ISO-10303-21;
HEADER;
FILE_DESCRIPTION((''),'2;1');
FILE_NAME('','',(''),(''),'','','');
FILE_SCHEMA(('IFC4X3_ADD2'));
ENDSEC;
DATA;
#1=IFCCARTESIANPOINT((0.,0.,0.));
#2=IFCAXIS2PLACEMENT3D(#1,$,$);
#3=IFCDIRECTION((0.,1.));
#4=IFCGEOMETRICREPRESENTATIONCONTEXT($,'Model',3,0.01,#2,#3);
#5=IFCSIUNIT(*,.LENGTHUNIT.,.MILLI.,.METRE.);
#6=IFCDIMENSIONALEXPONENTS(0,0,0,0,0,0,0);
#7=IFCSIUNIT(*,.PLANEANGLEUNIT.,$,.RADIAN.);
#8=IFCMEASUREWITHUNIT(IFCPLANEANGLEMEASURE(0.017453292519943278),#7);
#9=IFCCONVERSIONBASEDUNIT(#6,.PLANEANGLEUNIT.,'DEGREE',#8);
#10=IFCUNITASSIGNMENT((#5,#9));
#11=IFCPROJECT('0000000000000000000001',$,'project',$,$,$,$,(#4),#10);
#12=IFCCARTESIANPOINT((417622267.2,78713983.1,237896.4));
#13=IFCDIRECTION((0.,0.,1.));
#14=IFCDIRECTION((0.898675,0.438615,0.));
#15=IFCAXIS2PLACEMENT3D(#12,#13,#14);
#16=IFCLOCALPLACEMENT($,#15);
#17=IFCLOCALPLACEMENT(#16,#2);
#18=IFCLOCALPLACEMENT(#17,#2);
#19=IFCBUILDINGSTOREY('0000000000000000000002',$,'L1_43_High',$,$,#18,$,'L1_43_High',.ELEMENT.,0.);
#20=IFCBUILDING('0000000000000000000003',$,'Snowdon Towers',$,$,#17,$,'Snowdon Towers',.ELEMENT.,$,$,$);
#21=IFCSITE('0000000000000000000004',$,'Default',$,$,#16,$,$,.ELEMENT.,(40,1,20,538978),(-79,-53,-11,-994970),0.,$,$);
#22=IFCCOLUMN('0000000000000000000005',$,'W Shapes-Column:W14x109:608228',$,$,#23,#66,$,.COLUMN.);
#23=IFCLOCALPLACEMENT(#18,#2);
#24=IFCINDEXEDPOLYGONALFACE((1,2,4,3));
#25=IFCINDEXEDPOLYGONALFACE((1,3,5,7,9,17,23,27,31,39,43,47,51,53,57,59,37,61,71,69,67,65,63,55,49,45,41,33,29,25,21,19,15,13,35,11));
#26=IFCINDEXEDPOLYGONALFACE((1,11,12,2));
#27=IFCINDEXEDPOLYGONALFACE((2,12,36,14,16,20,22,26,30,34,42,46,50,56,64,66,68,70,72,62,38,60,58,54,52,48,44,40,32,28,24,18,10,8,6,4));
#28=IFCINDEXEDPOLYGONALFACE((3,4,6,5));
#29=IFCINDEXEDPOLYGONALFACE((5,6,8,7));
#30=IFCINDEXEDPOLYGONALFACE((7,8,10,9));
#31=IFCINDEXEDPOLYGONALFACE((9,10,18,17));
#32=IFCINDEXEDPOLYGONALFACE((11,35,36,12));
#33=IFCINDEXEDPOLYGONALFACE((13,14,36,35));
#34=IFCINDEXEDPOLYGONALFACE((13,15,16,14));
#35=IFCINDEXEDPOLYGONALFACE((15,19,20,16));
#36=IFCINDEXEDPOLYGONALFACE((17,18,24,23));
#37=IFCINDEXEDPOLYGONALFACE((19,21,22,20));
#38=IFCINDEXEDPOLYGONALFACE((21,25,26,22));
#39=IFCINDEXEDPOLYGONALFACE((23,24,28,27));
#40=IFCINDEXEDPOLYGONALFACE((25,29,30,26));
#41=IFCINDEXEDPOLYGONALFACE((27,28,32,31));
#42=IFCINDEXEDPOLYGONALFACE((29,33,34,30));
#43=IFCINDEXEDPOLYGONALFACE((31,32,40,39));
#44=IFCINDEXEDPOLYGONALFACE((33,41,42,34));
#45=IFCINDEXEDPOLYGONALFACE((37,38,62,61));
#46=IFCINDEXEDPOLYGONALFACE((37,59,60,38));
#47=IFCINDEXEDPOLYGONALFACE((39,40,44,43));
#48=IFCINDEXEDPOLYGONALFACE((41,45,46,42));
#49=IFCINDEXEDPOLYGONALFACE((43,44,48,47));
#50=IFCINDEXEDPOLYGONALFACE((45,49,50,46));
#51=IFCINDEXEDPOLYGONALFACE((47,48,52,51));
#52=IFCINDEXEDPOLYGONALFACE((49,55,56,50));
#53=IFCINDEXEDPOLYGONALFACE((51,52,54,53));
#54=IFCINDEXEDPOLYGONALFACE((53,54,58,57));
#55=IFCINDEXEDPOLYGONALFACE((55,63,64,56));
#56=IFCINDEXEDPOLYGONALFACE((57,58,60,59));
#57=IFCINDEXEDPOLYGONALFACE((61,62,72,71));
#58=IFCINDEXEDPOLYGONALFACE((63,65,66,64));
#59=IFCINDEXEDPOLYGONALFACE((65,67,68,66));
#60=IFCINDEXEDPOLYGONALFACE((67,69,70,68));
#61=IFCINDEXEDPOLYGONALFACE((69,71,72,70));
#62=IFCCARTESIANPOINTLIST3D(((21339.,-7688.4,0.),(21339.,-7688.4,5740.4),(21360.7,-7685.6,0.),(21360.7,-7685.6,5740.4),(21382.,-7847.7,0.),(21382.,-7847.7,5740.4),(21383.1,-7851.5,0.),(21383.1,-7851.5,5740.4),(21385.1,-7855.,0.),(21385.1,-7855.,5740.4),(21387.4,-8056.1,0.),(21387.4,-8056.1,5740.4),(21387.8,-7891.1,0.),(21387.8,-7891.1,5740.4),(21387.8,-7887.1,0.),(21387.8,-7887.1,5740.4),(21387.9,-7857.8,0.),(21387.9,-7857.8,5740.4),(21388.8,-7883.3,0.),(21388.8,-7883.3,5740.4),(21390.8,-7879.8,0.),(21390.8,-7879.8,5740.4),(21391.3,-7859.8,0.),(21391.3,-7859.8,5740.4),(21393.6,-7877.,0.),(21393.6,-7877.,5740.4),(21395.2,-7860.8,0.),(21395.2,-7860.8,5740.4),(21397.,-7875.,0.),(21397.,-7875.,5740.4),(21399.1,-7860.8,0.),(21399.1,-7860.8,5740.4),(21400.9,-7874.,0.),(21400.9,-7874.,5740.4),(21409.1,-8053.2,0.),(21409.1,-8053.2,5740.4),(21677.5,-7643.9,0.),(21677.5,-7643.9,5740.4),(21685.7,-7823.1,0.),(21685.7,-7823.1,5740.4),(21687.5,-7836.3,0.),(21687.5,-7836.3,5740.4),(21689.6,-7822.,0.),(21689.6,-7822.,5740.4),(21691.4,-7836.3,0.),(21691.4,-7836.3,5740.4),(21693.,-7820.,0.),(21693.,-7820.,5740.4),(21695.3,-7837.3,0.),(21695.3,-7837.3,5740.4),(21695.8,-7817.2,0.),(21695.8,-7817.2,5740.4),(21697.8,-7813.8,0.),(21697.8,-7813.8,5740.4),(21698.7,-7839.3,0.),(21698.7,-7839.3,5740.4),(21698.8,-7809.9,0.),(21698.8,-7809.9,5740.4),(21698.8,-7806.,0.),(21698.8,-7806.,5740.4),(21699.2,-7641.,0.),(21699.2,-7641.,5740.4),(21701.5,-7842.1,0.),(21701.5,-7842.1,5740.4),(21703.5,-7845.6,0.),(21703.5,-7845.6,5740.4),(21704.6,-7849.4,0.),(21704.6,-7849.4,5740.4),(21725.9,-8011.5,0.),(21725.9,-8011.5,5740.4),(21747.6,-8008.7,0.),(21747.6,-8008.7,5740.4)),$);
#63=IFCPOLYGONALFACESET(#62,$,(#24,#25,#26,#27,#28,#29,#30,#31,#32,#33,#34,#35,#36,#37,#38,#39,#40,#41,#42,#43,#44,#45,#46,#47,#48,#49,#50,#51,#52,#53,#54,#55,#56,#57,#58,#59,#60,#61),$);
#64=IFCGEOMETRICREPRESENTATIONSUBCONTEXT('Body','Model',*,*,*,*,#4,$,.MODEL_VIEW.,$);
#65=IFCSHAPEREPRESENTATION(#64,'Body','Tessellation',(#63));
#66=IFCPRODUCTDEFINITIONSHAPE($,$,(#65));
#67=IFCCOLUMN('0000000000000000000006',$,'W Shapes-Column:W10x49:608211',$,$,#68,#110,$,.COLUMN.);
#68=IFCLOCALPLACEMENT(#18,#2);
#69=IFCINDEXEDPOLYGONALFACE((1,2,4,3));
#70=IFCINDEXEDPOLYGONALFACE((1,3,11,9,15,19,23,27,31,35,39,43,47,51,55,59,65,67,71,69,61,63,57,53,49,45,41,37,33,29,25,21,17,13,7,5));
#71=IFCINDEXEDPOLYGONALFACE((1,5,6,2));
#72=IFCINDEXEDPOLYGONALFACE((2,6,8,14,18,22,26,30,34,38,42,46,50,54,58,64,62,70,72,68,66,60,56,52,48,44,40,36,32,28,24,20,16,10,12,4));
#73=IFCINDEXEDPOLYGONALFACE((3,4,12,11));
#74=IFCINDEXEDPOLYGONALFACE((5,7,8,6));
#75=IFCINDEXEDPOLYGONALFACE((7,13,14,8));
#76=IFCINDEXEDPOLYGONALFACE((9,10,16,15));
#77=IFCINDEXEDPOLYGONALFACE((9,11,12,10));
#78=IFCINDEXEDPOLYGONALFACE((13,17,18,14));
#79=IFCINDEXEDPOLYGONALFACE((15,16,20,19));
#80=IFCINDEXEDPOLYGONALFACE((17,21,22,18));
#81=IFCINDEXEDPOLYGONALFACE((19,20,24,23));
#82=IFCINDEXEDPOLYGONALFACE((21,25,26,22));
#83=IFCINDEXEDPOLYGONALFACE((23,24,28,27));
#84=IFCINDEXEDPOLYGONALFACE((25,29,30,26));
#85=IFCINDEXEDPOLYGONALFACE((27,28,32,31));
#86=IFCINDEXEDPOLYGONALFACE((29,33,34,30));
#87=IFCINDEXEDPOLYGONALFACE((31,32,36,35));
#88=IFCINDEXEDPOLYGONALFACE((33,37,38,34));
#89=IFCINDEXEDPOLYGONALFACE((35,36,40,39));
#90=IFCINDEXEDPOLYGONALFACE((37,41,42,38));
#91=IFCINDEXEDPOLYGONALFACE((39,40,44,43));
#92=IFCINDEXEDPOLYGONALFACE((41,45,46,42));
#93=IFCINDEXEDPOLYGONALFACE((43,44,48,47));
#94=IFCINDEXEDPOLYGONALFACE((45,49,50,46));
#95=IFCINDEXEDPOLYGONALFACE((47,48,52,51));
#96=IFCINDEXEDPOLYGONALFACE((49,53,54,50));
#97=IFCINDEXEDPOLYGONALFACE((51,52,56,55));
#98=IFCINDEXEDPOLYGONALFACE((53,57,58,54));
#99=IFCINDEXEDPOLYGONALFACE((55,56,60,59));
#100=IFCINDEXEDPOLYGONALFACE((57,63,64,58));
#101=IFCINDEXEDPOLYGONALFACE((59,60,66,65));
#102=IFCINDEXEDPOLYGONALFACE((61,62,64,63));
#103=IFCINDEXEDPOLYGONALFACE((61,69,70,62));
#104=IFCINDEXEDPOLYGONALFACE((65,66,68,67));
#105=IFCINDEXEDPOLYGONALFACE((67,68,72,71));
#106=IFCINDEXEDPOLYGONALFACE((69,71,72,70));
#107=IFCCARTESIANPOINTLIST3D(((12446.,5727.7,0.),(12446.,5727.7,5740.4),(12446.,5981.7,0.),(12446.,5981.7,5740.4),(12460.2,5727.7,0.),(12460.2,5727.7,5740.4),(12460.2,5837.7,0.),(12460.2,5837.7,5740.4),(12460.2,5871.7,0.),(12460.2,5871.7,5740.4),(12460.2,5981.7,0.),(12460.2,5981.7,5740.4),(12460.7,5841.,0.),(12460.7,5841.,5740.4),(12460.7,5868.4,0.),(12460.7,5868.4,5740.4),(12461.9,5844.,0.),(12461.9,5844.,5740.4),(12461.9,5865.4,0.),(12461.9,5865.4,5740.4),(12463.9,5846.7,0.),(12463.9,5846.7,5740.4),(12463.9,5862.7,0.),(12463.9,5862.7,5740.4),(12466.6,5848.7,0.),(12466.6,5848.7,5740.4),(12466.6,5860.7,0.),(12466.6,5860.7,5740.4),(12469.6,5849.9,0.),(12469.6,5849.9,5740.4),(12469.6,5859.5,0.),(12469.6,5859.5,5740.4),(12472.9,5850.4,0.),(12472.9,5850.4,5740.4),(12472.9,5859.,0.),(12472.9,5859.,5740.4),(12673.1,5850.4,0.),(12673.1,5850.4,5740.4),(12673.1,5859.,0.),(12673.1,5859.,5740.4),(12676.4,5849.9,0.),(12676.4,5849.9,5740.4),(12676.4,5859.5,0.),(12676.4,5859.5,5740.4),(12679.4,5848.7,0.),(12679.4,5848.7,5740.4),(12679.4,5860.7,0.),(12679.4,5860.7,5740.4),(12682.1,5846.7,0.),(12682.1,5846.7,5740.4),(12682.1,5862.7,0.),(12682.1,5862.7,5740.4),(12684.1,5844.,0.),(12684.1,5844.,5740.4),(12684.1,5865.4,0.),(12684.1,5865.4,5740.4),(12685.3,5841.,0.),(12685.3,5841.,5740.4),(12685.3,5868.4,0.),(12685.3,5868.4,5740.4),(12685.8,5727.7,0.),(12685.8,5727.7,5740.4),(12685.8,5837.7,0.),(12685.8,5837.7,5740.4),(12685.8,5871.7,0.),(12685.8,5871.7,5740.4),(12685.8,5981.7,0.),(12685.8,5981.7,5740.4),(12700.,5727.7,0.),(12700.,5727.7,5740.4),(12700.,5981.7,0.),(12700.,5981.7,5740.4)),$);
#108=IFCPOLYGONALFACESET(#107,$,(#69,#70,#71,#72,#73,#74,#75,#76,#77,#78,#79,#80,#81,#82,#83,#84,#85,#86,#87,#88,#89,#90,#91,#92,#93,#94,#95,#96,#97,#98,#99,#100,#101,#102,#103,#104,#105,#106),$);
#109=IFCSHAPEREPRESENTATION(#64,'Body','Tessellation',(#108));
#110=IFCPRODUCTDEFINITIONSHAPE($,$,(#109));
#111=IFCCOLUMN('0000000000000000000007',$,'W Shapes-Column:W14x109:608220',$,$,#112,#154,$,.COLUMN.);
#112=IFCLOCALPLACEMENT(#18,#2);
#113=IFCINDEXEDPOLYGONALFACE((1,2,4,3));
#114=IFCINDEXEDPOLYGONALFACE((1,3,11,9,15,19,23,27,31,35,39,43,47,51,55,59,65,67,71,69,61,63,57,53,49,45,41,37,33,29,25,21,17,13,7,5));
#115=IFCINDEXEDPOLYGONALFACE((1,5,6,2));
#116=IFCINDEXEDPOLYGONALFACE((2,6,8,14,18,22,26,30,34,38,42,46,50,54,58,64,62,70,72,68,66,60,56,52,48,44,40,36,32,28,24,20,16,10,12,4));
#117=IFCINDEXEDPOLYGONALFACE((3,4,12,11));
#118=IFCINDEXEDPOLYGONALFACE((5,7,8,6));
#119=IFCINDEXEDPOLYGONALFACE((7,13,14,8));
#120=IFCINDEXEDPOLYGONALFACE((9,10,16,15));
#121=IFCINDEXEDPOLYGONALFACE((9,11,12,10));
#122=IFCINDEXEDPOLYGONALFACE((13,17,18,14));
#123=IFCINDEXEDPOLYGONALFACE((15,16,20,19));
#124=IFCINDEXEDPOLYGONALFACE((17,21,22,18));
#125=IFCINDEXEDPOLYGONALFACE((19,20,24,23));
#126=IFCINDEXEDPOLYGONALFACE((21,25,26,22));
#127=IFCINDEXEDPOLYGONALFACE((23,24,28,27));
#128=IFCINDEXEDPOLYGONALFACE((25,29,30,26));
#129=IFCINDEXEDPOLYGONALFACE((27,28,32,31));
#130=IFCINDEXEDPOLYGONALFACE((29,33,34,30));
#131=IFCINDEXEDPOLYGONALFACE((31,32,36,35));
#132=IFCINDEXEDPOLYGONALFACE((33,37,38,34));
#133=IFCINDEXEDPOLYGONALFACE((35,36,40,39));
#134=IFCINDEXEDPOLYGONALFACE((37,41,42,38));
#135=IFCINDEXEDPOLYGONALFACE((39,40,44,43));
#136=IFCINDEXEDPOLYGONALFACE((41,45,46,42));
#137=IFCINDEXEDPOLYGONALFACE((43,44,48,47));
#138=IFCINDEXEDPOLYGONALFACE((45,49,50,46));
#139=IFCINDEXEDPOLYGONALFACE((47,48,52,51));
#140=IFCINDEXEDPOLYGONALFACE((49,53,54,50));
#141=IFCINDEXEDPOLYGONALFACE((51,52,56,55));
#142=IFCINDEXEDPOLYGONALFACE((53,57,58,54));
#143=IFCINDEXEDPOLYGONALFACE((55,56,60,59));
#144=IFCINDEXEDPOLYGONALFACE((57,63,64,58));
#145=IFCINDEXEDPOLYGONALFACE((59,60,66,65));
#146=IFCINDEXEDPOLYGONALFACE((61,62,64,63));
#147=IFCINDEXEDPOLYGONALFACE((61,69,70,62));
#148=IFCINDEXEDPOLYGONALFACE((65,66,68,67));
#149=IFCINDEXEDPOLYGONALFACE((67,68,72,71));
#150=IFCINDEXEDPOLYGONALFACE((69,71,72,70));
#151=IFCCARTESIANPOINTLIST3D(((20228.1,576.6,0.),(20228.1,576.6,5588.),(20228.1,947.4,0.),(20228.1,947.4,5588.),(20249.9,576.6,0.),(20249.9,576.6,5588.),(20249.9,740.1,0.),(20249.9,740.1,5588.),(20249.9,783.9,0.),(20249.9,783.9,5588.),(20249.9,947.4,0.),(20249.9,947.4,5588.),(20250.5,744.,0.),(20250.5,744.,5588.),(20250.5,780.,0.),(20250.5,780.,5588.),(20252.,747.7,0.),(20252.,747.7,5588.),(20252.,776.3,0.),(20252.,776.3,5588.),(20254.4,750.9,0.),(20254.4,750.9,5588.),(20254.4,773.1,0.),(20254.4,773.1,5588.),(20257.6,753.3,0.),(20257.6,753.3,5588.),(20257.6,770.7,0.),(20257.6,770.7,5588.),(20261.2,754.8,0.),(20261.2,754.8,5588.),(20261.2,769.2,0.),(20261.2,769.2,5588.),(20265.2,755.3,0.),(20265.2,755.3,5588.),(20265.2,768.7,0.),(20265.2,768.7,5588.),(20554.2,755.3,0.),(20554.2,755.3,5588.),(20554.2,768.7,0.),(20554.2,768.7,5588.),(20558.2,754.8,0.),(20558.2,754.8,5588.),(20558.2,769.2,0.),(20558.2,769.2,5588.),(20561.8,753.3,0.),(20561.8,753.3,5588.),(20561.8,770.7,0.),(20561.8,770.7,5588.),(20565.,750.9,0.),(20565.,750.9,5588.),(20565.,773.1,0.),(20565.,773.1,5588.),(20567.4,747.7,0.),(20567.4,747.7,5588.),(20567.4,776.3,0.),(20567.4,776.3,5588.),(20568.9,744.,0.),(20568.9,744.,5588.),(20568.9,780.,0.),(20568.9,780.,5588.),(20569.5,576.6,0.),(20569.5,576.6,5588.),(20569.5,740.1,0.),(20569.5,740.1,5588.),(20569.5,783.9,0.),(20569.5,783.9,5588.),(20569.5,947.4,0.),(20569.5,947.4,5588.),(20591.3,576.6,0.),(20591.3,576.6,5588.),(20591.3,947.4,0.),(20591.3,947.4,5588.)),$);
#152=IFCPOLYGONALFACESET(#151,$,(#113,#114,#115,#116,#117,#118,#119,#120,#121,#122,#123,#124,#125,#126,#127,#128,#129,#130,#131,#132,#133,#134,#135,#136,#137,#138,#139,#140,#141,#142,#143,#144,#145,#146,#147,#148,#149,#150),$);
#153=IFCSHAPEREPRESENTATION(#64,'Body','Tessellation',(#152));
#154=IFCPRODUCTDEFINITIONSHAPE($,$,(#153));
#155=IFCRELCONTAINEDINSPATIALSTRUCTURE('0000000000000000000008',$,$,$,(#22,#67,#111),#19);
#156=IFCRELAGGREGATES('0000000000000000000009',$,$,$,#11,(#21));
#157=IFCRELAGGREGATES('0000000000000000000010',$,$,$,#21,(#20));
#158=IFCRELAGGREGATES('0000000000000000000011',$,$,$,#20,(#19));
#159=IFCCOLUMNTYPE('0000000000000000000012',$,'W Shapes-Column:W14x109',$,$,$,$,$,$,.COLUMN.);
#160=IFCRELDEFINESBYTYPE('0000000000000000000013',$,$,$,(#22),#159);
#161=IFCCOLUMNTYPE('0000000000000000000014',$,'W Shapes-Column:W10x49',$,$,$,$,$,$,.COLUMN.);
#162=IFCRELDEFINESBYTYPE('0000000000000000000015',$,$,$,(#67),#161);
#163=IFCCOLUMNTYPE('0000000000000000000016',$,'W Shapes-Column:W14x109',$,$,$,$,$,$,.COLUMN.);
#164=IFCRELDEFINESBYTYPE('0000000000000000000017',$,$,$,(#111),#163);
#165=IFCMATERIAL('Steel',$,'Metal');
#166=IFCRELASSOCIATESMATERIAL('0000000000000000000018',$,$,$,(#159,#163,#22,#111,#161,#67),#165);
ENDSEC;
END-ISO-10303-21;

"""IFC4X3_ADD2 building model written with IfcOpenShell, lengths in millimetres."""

from ifc_helpers import new_model, entity, si_unit, converted_unit, direction, frame, frame_2d, origin, place, context, subcontext, project, spatial, i_section, extrude, source, transform, mapped, material, material_profile, profile_set, profile_usage, type_object, type_shapes, element, save


model = new_model("IFC4X3_ADD2")

# Units and contexts
model_context = context("Model", 3, precision=0.01, world=origin(), true_north=direction((0.0, 1.0)))
body_context = subcontext(model_context, "Body", "Model", "MODEL_VIEW")
ifc_project = project(units=[si_unit("LENGTHUNIT", "METRE", prefix="MILLI"), converted_unit("PLANEANGLEUNIT", "DEGREE", entity("IfcPlaneAngleMeasure", 0.017453292519943278), si_unit("PLANEANGLEUNIT", "RADIAN"), dimensions=[0, 0, 0, 0, 0, 0, 0])], contexts=[model_context])

# Site, building, storey
site_placement = place(None, frame((417622267.2, 78713983.1, 237896.4), z_axis=(0.0, 0.0, 1.0), x_axis=(0.898675, 0.438615, 0.0)))
site = spatial("IfcSite", under=ifc_project, at=site_placement, Name="Default", CompositionType="ELEMENT", RefLatitude=(40, 1, 20, 538978), RefLongitude=(-79, -53, -11, -994970), RefElevation=0.0)
building_placement = place(site_placement, origin())
building = spatial("IfcBuilding", under=site, at=building_placement, Name="Snowdon Towers", LongName="Snowdon Towers", CompositionType="ELEMENT")
storey_placement = place(building_placement, origin())
storey = spatial("IfcBuildingStorey", under=building, at=storey_placement, Name="L1_43_High", LongName="L1_43_High", CompositionType="ELEMENT", Elevation=0.0)

# Columns
ifc_material_1 = material(Name="Steel", Category="Metal")
ifc_material_profile_1 = material_profile(ifc_material_1, i_section(OverallWidth=370.8, OverallDepth=363.2, WebThickness=13.3, FlangeThickness=21.8, FilletRadius=15.2, at=frame_2d((0.0, 0.0), x_axis=(1.0, 0.0))), Name="W14x109")
ifc_profile_set_1 = profile_set([ifc_material_profile_1], Name="W14x109")
ifc_profile_usage_1 = profile_usage(ifc_profile_set_1)
column_type_1 = type_object("IfcColumnType", Name="W Shapes-Column:W14x109", PredefinedType="COLUMN", material=ifc_profile_set_1)
shared_shape_1 = source(origin(), body_context, "Body", "SweptSolid", [
    extrude(i_section(OverallWidth=370.8, OverallDepth=363.2, WebThickness=13.3, FlangeThickness=21.8, FilletRadius=15.2, at=frame_2d((0.0, 0.0), x_axis=(1.0, 0.0))), frame((0.0, 0.0, 0.0), z_axis=(0.0, 0.0, 1.0), x_axis=(-1.0, 0.0, 0.0)), (0.0, 0.0, 1.0), 5740.4),
])
type_shapes(column_type_1, [shared_shape_1])
for number, where, z_axis, x_axis, name in (
    (1, (21543.3, -7848.5, 0.0), (0.0, 0.0, 1.0), (-0.130526, 0.991445, 0.0), "W Shapes-Column:W14x109:608228"),
):
    element("IfcColumn", number, at=place(storey_placement, frame(where, z_axis=z_axis, x_axis=x_axis)), inside=storey, type_object=column_type_1, material=ifc_profile_usage_1, Name=name, PredefinedType="COLUMN", context=body_context, shape_type="MappedRepresentation", body=[
        mapped(shared_shape_1, transform((0.0, 0.0, 0.0), scale=1.0)),
    ])
ifc_material_profile_2 = material_profile(ifc_material_1, i_section(OverallWidth=254.0, OverallDepth=254.0, WebThickness=8.6, FlangeThickness=14.2, FilletRadius=12.7, at=frame_2d((0.0, 0.0), x_axis=(1.0, 0.0))), Name="W10x49")
ifc_profile_set_2 = profile_set([ifc_material_profile_2], Name="W10x49")
ifc_profile_usage_2 = profile_usage(ifc_profile_set_2)
column_type_2 = type_object("IfcColumnType", Name="W Shapes-Column:W10x49", PredefinedType="COLUMN", material=ifc_profile_set_2)
shared_shape_2 = source(origin(), body_context, "Body", "SweptSolid", [
    extrude(i_section(OverallWidth=254.0, OverallDepth=254.0, WebThickness=8.6, FlangeThickness=14.2, FilletRadius=12.7, at=frame_2d((0.0, 0.0), x_axis=(1.0, 0.0))), frame((0.0, 0.0, 0.0), z_axis=(0.0, 0.0, 1.0), x_axis=(-1.0, 0.0, 0.0)), (0.0, 0.0, 1.0), 5740.4),
])
type_shapes(column_type_2, [shared_shape_2])
column_1_placement = place(storey_placement, frame((12573.0, 5854.7, 0.0), z_axis=(0.0, 0.0, 1.0), x_axis=(0.0, 1.0, 0.0)))
element("IfcColumn", 2, at=column_1_placement, inside=storey, type_object=column_type_2, material=ifc_profile_usage_2, Name="W Shapes-Column:W10x49:608211", PredefinedType="COLUMN", context=body_context, shape_type="MappedRepresentation", body=[
    mapped(shared_shape_2, transform((0.0, 0.0, 0.0), scale=1.0)),
])
column_type_3 = type_object("IfcColumnType", Name="W Shapes-Column:W14x109", PredefinedType="COLUMN", material=ifc_profile_set_1)
shared_shape_3 = source(origin(), body_context, "Body", "SweptSolid", [
    extrude(i_section(OverallWidth=370.8, OverallDepth=363.2, WebThickness=13.3, FlangeThickness=21.8, FilletRadius=15.2, at=frame_2d((0.0, 0.0), x_axis=(1.0, 0.0))), frame((0.0, 0.0, 0.0), z_axis=(0.0, 0.0, 1.0), x_axis=(-1.0, 0.0, 0.0)), (0.0, 0.0, 1.0), 5588.0),
])
type_shapes(column_type_3, [shared_shape_3])
for number, where, z_axis, x_axis, name in (
    (3, (20409.7, 762.0, 0.0), (0.0, 0.0, 1.0), (0.0, 1.0, 0.0), "W Shapes-Column:W14x109:608220"),
):
    element("IfcColumn", number, at=place(storey_placement, frame(where, z_axis=z_axis, x_axis=x_axis)), inside=storey, type_object=column_type_3, material=ifc_profile_usage_1, Name=name, PredefinedType="COLUMN", context=body_context, shape_type="MappedRepresentation", body=[
        mapped(shared_shape_3, transform((0.0, 0.0, 0.0), scale=1.0)),
    ])

save(model, "model.ifc")
